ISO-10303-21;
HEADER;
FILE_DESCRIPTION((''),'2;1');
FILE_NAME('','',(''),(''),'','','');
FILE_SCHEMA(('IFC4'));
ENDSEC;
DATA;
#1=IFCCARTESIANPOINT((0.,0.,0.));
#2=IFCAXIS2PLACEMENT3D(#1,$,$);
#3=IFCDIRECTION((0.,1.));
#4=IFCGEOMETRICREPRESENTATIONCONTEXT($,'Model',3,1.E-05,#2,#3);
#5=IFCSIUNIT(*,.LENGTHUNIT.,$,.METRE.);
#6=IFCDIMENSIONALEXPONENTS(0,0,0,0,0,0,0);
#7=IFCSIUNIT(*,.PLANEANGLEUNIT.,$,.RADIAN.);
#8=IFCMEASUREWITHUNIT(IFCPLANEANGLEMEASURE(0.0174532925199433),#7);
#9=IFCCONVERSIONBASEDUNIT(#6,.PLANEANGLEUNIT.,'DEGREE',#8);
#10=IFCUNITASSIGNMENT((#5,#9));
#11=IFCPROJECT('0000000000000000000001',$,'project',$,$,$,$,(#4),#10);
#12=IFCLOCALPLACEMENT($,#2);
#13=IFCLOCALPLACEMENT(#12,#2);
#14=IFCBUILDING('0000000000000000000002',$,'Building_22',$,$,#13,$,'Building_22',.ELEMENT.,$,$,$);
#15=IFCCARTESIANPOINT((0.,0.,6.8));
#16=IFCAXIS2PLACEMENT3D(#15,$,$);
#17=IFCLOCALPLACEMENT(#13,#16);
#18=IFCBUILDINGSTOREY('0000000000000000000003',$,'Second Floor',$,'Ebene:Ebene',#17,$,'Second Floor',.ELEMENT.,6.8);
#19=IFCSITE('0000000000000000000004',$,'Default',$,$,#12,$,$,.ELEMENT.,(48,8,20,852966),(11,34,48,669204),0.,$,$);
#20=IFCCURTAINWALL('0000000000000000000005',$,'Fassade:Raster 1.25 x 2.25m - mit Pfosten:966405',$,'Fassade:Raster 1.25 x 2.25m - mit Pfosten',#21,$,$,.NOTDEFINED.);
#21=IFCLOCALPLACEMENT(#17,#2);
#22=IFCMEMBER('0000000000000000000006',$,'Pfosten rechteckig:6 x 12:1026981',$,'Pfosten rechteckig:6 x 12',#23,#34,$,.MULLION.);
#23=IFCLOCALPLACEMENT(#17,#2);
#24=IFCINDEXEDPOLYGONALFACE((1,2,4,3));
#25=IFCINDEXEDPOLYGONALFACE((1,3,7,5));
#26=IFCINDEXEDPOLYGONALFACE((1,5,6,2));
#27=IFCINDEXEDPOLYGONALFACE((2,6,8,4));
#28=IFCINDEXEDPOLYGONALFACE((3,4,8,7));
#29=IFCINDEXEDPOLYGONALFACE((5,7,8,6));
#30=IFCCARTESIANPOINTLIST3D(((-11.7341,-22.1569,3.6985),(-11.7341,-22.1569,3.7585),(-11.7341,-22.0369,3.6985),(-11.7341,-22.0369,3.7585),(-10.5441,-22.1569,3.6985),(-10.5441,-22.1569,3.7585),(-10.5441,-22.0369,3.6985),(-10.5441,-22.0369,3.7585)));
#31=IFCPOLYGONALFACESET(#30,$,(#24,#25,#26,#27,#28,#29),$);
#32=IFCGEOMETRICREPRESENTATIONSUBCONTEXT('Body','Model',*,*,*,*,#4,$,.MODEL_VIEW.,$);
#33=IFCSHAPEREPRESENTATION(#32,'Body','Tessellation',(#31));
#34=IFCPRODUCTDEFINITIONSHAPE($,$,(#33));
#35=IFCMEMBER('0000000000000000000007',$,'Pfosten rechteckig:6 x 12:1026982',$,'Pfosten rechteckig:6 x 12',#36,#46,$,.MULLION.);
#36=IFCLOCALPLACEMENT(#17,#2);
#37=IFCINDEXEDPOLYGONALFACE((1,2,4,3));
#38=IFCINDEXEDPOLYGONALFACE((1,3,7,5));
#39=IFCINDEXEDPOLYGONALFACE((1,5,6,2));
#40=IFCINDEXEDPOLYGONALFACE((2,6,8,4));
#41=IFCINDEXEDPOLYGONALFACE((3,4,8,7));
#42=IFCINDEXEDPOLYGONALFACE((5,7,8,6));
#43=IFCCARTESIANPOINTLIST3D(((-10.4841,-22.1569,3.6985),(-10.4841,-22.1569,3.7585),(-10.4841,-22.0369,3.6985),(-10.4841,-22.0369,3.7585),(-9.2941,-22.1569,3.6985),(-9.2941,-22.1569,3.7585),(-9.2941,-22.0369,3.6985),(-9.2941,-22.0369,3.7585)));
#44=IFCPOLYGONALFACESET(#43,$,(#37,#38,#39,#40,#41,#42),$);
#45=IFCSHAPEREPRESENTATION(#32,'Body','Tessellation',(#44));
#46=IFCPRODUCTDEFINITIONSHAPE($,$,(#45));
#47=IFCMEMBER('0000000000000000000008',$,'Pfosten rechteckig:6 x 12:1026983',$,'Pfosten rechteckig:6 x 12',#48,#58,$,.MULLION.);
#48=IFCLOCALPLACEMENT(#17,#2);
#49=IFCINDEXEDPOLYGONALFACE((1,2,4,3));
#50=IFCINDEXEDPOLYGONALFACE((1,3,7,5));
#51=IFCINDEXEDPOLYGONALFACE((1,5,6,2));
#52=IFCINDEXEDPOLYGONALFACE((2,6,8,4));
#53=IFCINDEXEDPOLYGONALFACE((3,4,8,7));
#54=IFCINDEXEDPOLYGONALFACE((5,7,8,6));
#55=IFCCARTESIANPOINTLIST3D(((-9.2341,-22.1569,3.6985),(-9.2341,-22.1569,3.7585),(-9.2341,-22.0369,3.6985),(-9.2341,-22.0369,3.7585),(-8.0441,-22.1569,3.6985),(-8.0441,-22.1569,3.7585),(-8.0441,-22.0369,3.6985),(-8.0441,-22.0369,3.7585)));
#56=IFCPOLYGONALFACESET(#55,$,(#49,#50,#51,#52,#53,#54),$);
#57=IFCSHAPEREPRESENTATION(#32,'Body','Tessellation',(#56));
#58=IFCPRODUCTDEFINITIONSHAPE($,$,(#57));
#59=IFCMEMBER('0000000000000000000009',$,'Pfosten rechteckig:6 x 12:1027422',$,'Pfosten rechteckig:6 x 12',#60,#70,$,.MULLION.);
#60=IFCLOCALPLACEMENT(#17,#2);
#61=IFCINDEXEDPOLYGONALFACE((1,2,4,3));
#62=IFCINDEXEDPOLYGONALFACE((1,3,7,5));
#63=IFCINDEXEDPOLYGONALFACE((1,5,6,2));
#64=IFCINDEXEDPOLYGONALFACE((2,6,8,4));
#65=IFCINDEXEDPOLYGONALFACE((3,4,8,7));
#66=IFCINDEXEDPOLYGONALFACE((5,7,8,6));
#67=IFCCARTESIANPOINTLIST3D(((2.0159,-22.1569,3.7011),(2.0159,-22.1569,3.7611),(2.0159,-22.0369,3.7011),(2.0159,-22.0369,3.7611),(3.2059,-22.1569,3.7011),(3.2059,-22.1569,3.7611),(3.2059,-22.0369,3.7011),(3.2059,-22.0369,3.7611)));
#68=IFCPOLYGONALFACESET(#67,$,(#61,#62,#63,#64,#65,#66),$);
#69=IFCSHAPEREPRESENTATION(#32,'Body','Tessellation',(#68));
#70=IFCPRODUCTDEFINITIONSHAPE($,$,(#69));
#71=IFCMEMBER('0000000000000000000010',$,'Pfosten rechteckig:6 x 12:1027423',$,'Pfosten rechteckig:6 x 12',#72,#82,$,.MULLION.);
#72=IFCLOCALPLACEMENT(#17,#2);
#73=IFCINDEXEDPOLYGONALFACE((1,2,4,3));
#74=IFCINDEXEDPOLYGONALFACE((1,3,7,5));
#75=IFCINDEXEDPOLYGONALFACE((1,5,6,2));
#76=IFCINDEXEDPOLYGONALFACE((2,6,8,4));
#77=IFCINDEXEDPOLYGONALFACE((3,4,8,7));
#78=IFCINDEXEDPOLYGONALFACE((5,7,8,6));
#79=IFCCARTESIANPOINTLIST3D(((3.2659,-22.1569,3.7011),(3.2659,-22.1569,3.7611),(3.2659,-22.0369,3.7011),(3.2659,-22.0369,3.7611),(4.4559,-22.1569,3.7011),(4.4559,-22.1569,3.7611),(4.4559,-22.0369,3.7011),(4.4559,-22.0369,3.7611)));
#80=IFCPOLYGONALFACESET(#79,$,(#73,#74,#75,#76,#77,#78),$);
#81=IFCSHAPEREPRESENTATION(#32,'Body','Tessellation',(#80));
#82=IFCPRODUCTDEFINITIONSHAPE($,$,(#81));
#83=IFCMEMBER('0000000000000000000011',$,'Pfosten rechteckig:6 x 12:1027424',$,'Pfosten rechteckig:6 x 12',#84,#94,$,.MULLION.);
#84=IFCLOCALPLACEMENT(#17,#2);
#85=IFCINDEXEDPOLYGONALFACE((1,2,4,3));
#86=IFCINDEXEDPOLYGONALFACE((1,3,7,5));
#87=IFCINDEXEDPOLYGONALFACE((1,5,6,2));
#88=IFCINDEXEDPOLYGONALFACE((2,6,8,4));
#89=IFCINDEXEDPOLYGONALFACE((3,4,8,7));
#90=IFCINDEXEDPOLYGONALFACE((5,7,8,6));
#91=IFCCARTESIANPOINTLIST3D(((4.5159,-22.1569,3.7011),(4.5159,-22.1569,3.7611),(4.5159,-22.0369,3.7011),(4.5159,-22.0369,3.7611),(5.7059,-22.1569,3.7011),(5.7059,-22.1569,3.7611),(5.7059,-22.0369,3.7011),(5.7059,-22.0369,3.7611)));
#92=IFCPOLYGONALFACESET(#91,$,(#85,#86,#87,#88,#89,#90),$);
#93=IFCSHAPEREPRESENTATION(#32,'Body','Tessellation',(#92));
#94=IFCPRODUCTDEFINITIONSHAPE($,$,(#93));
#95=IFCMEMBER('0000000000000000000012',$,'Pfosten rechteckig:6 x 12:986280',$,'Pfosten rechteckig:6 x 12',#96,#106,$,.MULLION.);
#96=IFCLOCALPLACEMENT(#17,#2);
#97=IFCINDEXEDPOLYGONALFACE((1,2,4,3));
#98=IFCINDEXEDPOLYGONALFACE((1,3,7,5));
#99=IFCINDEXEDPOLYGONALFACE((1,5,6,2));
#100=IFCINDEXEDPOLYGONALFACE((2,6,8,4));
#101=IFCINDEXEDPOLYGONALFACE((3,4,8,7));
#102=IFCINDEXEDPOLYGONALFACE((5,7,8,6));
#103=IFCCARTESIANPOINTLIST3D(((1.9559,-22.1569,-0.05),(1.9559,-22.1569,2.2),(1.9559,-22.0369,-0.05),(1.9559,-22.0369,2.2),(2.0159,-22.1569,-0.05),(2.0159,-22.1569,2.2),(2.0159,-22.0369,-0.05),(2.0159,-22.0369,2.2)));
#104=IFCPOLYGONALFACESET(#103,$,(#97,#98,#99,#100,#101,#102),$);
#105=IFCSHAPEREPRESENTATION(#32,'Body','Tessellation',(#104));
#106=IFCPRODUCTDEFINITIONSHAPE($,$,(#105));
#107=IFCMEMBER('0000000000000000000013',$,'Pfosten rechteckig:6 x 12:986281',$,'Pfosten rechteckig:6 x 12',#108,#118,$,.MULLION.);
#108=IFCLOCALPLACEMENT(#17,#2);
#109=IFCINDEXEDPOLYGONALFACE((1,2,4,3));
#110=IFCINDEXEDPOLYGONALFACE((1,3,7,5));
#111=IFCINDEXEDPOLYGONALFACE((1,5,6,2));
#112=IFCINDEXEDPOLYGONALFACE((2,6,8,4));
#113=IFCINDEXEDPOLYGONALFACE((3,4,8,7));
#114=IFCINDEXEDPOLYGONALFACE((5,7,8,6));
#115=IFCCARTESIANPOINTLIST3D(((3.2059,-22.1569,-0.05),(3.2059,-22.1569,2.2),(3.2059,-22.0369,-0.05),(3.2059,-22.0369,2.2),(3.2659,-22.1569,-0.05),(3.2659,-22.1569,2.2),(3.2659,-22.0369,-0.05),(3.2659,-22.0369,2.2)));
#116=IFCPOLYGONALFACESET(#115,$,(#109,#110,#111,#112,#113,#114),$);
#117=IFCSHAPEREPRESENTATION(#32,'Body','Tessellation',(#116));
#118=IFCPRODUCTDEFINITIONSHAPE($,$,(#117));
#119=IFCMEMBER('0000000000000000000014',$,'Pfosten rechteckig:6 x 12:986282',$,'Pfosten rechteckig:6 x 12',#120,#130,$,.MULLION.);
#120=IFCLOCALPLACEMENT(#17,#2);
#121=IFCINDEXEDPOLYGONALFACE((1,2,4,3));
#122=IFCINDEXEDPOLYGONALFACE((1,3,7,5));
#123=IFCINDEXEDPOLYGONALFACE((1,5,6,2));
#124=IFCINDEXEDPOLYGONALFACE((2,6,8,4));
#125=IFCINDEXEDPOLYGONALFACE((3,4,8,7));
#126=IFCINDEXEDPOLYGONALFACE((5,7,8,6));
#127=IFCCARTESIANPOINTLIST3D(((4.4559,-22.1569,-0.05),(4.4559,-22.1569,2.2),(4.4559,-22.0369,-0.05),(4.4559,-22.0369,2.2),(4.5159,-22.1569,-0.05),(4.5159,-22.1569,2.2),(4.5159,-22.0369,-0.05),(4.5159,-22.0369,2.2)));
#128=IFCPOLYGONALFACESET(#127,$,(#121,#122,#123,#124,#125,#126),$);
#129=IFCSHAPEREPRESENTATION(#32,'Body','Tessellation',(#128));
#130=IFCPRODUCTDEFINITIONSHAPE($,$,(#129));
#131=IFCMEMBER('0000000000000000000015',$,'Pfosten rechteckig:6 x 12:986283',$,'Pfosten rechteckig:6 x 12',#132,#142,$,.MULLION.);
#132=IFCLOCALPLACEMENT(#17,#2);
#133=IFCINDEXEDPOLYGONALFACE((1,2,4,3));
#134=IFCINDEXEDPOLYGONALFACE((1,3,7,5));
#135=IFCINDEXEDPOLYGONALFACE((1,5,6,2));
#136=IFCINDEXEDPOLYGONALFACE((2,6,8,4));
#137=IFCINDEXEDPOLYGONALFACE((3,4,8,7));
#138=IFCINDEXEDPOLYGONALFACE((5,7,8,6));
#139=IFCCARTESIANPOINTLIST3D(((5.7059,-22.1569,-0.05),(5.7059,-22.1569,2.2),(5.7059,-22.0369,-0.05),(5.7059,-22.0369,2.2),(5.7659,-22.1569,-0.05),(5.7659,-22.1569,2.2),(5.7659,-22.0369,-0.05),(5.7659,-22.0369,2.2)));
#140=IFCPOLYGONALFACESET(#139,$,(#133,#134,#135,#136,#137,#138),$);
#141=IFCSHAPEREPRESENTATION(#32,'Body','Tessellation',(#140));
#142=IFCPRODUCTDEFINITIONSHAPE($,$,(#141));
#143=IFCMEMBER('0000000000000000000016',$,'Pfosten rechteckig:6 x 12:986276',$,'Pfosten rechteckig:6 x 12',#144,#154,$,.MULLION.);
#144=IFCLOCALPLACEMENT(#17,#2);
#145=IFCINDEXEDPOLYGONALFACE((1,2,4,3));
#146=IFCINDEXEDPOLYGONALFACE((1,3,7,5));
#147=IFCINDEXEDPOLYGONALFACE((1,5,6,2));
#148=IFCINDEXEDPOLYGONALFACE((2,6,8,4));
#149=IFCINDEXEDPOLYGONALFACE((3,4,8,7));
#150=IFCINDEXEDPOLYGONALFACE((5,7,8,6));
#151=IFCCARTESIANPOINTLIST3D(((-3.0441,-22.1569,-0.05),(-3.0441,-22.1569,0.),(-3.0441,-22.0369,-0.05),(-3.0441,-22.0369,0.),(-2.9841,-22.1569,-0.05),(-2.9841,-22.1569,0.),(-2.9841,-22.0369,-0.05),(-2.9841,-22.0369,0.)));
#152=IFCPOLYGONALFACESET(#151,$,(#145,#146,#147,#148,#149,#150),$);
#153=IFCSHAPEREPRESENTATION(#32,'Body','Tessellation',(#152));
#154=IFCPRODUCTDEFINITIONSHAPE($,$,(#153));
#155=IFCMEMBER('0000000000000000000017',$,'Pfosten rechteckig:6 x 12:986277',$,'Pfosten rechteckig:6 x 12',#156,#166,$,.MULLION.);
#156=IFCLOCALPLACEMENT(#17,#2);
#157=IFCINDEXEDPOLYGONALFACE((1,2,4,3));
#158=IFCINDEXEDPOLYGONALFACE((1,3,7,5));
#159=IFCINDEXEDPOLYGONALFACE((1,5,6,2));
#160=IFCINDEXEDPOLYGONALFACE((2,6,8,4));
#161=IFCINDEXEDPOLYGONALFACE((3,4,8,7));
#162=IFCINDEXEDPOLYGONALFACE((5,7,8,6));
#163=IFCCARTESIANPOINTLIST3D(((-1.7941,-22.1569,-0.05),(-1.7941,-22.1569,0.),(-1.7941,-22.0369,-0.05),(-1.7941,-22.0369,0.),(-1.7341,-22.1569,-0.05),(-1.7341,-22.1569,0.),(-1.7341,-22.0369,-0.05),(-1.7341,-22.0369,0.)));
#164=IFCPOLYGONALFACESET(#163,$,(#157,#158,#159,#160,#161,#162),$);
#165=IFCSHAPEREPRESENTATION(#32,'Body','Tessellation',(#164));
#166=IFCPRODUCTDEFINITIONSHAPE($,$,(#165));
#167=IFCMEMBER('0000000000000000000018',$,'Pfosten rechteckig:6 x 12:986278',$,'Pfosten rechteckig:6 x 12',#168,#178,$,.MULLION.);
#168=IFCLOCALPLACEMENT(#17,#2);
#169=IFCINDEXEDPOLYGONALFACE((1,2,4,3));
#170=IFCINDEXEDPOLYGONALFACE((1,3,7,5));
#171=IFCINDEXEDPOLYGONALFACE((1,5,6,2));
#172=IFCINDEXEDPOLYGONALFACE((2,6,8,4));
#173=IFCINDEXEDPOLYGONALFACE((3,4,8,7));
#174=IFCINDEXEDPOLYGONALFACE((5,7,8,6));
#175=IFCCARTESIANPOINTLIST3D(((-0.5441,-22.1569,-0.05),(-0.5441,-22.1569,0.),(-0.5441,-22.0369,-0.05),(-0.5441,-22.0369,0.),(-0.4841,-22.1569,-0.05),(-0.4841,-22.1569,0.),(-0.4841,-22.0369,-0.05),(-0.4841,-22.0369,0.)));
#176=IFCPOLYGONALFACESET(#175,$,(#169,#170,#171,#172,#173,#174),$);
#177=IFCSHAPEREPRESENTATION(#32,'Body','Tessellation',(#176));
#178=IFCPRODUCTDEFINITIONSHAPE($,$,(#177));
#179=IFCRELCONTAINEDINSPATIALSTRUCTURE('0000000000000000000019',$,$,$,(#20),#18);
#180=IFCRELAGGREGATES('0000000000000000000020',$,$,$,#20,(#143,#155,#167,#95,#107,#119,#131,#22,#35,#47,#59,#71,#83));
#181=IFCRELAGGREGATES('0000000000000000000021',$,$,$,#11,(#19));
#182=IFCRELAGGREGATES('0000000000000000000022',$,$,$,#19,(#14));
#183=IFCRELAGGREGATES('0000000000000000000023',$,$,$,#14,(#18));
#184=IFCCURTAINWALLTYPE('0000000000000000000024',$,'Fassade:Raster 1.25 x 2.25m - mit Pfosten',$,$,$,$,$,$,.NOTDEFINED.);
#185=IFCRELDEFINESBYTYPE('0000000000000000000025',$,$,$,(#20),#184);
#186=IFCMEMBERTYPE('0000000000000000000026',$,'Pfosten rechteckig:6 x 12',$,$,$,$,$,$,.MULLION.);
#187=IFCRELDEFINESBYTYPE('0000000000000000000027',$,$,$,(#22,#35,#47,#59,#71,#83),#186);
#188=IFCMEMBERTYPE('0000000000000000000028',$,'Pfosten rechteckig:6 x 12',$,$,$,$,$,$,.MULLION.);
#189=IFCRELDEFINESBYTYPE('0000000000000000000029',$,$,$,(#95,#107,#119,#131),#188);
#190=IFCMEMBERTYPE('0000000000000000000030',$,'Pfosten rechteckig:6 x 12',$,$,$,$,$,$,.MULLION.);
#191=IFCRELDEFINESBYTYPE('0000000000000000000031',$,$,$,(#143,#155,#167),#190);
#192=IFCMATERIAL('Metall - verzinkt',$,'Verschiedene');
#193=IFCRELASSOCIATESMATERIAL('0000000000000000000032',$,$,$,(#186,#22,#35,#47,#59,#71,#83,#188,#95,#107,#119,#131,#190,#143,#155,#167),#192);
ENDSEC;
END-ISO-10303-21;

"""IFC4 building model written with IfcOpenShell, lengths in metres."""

from ifc_helpers import new_model, entity, si_unit, converted_unit, direction, frame, origin, place, context, subcontext, project, spatial, indexed_curve, outline, extrude, source, transform, mapped, material, type_object, type_shapes, element, aggregate, save


model = new_model("IFC4")

# Units and contexts
model_context = context("Model", 3, precision=1e-05, world=origin(), true_north=direction((0.0, 1.0)))
body_context = subcontext(model_context, "Body", "Model", "MODEL_VIEW")
ifc_project = project(units=[si_unit("LENGTHUNIT", "METRE"), converted_unit("PLANEANGLEUNIT", "DEGREE", entity("IfcPlaneAngleMeasure", 0.0174532925199433), si_unit("PLANEANGLEUNIT", "RADIAN"), dimensions=[0, 0, 0, 0, 0, 0, 0])], contexts=[model_context])

# Site, building, storey
site_placement = place(None, origin())
site = spatial("IfcSite", under=ifc_project, at=site_placement, Name="Default", CompositionType="ELEMENT", RefLatitude=(48, 8, 20, 852966), RefLongitude=(11, 34, 48, 669204), RefElevation=0.0)
building_placement = place(site_placement, origin())
building = spatial("IfcBuilding", under=site, at=building_placement, Name="Building_22", LongName="Building_22", CompositionType="ELEMENT")
storey_placement = place(building_placement, frame((0.0, 0.0, 6.8)))
storey = spatial("IfcBuildingStorey", under=building, at=storey_placement, Name="Second Floor", ObjectType="Ebene:Ebene", LongName="Second Floor", CompositionType="ELEMENT", Elevation=6.8)

# Curtain wall, members
curtain_wall_type = type_object("IfcCurtainWallType", Name="Fassade:Raster 1.25 x 2.25m - mit Pfosten", PredefinedType="NOTDEFINED")
curtain_wall_placement = place(storey_placement, frame((0.0, 0.0, -6.8)))
curtain_wall = element("IfcCurtainWall", 1, at=curtain_wall_placement, inside=storey, type_object=curtain_wall_type, Name="Fassade:Raster 1.25 x 2.25m - mit Pfosten:966405", ObjectType="Fassade:Raster 1.25 x 2.25m - mit Pfosten", PredefinedType="NOTDEFINED")
ifc_material = material(Name="Metall - verzinkt", Category="Verschiedene")
member_type_1 = type_object("IfcMemberType", Name="Pfosten rechteckig:6 x 12", PredefinedType="MULLION", material=ifc_material)
shared_shape_1 = source(origin(), body_context, "Body", "SweptSolid", [
    extrude(outline(indexed_curve([(-0.03, -0.06), (0.03, -0.06), (0.03, 0.06), (-0.03, 0.06), (-0.03, -0.06)], self_intersect=False)), frame((-0.03, 0.0, -1.19), z_axis=(0.0, 0.0, 1.0), x_axis=(-1.0, 0.0, 0.0)), (0.0, 0.0, 1.0), 1.19),
])
type_shapes(member_type_1, [shared_shape_1])
member_1_placement = place(curtain_wall_placement, frame((-10.5441, -22.0969, 10.5585), z_axis=(1.0, 0.0, 0.0), x_axis=(0.0, 0.0, 1.0)))
member_1 = element("IfcMember", 2, at=member_1_placement, type_object=member_type_1, material=ifc_material, Name="Pfosten rechteckig:6 x 12:1026981", ObjectType="Pfosten rechteckig:6 x 12", PredefinedType="MULLION", context=body_context, shape_type="MappedRepresentation", body=[
    mapped(shared_shape_1, transform((0.0, 0.0, 0.0), scale=1.0)),
])
member_2_placement = place(curtain_wall_placement, frame((-9.2941, -22.0969, 10.5585), z_axis=(1.0, 0.0, 0.0), x_axis=(0.0, 0.0, 1.0)))
member_2 = element("IfcMember", 3, at=member_2_placement, type_object=member_type_1, material=ifc_material, Name="Pfosten rechteckig:6 x 12:1026982", ObjectType="Pfosten rechteckig:6 x 12", PredefinedType="MULLION", context=body_context, shape_type="MappedRepresentation", body=[
    mapped(shared_shape_1, transform((0.0, 0.0, 0.0), scale=1.0)),
])
member_3_placement = place(curtain_wall_placement, frame((-8.0441, -22.0969, 10.5585), z_axis=(1.0, 0.0, 0.0), x_axis=(0.0, 0.0, 1.0)))
member_3 = element("IfcMember", 4, at=member_3_placement, type_object=member_type_1, material=ifc_material, Name="Pfosten rechteckig:6 x 12:1026983", ObjectType="Pfosten rechteckig:6 x 12", PredefinedType="MULLION", context=body_context, shape_type="MappedRepresentation", body=[
    mapped(shared_shape_1, transform((0.0, 0.0, 0.0), scale=1.0)),
])
member_4_placement = place(curtain_wall_placement, frame((3.2059, -22.0969, 10.5611), z_axis=(1.0, 0.0, 0.0), x_axis=(0.0, 0.0, 1.0)))
member_4 = element("IfcMember", 5, at=member_4_placement, type_object=member_type_1, material=ifc_material, Name="Pfosten rechteckig:6 x 12:1027422", ObjectType="Pfosten rechteckig:6 x 12", PredefinedType="MULLION", context=body_context, shape_type="MappedRepresentation", body=[
    mapped(shared_shape_1, transform((0.0, 0.0, 0.0), scale=1.0)),
])
member_5_placement = place(curtain_wall_placement, frame((4.4559, -22.0969, 10.5611), z_axis=(1.0, 0.0, 0.0), x_axis=(0.0, 0.0, 1.0)))
member_5 = element("IfcMember", 6, at=member_5_placement, type_object=member_type_1, material=ifc_material, Name="Pfosten rechteckig:6 x 12:1027423", ObjectType="Pfosten rechteckig:6 x 12", PredefinedType="MULLION", context=body_context, shape_type="MappedRepresentation", body=[
    mapped(shared_shape_1, transform((0.0, 0.0, 0.0), scale=1.0)),
])
member_6_placement = place(curtain_wall_placement, frame((5.7059, -22.0969, 10.5611), z_axis=(1.0, 0.0, 0.0), x_axis=(0.0, 0.0, 1.0)))
member_6 = element("IfcMember", 7, at=member_6_placement, type_object=member_type_1, material=ifc_material, Name="Pfosten rechteckig:6 x 12:1027424", ObjectType="Pfosten rechteckig:6 x 12", PredefinedType="MULLION", context=body_context, shape_type="MappedRepresentation", body=[
    mapped(shared_shape_1, transform((0.0, 0.0, 0.0), scale=1.0)),
])
member_type_2 = type_object("IfcMemberType", Name="Pfosten rechteckig:6 x 12", PredefinedType="MULLION", material=ifc_material)
shared_shape_2 = source(origin(), body_context, "Body", "SweptSolid", [
    extrude(outline(indexed_curve([(-0.03, -0.06), (0.03, -0.06), (0.03, 0.06), (-0.03, 0.06), (-0.03, -0.06)], self_intersect=False)), frame((0.0, 0.0, -2.25), z_axis=(0.0, 0.0, 1.0), x_axis=(-1.0, 0.0, 0.0)), (0.0, 0.0, 1.0), 2.25),
])
type_shapes(member_type_2, [shared_shape_2])
member_7_placement = place(curtain_wall_placement, frame((1.9859, -22.0969, 6.75), z_axis=(0.0, 0.0, -1.0), x_axis=(1.0, 0.0, 0.0)))
member_7 = element("IfcMember", 8, at=member_7_placement, type_object=member_type_2, material=ifc_material, Name="Pfosten rechteckig:6 x 12:986280", ObjectType="Pfosten rechteckig:6 x 12", PredefinedType="MULLION", context=body_context, shape_type="MappedRepresentation", body=[
    mapped(shared_shape_2, transform((0.0, 0.0, 0.0), scale=1.0)),
])
member_8_placement = place(curtain_wall_placement, frame((3.2359, -22.0969, 6.75), z_axis=(0.0, 0.0, -1.0), x_axis=(1.0, 0.0, 0.0)))
member_8 = element("IfcMember", 9, at=member_8_placement, type_object=member_type_2, material=ifc_material, Name="Pfosten rechteckig:6 x 12:986281", ObjectType="Pfosten rechteckig:6 x 12", PredefinedType="MULLION", context=body_context, shape_type="MappedRepresentation", body=[
    mapped(shared_shape_2, transform((0.0, 0.0, 0.0), scale=1.0)),
])
member_9_placement = place(curtain_wall_placement, frame((4.4859, -22.0969, 6.75), z_axis=(0.0, 0.0, -1.0), x_axis=(1.0, 0.0, 0.0)))
member_9 = element("IfcMember", 10, at=member_9_placement, type_object=member_type_2, material=ifc_material, Name="Pfosten rechteckig:6 x 12:986282", ObjectType="Pfosten rechteckig:6 x 12", PredefinedType="MULLION", context=body_context, shape_type="MappedRepresentation", body=[
    mapped(shared_shape_2, transform((0.0, 0.0, 0.0), scale=1.0)),
])
member_10_placement = place(curtain_wall_placement, frame((5.7359, -22.0969, 6.75), z_axis=(0.0, 0.0, -1.0), x_axis=(1.0, 0.0, 0.0)))
member_10 = element("IfcMember", 11, at=member_10_placement, type_object=member_type_2, material=ifc_material, Name="Pfosten rechteckig:6 x 12:986283", ObjectType="Pfosten rechteckig:6 x 12", PredefinedType="MULLION", context=body_context, shape_type="MappedRepresentation", body=[
    mapped(shared_shape_2, transform((0.0, 0.0, 0.0), scale=1.0)),
])
member_type_3 = type_object("IfcMemberType", Name="Pfosten rechteckig:6 x 12", PredefinedType="MULLION", material=ifc_material)
shared_shape_3 = source(origin(), body_context, "Body", "SweptSolid", [
    extrude(outline(indexed_curve([(-0.03, -0.06), (0.03, -0.06), (0.03, 0.06), (-0.03, 0.06), (-0.03, -0.06)], self_intersect=False)), frame((0.0, 0.0, -0.05), z_axis=(0.0, 0.0, 1.0), x_axis=(-1.0, 0.0, 0.0)), (0.0, 0.0, 1.0), 0.05),
])
type_shapes(member_type_3, [shared_shape_3])
member_11_placement = place(curtain_wall_placement, frame((-3.0141, -22.0969, 6.75), z_axis=(0.0, 0.0, -1.0), x_axis=(1.0, 0.0, 0.0)))
member_11 = element("IfcMember", 12, at=member_11_placement, type_object=member_type_3, material=ifc_material, Name="Pfosten rechteckig:6 x 12:986276", ObjectType="Pfosten rechteckig:6 x 12", PredefinedType="MULLION", context=body_context, shape_type="MappedRepresentation", body=[
    mapped(shared_shape_3, transform((0.0, 0.0, 0.0), scale=1.0)),
])
member_12_placement = place(curtain_wall_placement, frame((-1.7641, -22.0969, 6.75), z_axis=(0.0, 0.0, -1.0), x_axis=(1.0, 0.0, 0.0)))
member_12 = element("IfcMember", 13, at=member_12_placement, type_object=member_type_3, material=ifc_material, Name="Pfosten rechteckig:6 x 12:986277", ObjectType="Pfosten rechteckig:6 x 12", PredefinedType="MULLION", context=body_context, shape_type="MappedRepresentation", body=[
    mapped(shared_shape_3, transform((0.0, 0.0, 0.0), scale=1.0)),
])
member_13_placement = place(curtain_wall_placement, frame((-0.5141, -22.0969, 6.75), z_axis=(0.0, 0.0, -1.0), x_axis=(1.0, 0.0, 0.0)))
member_13 = element("IfcMember", 14, at=member_13_placement, type_object=member_type_3, material=ifc_material, Name="Pfosten rechteckig:6 x 12:986278", ObjectType="Pfosten rechteckig:6 x 12", PredefinedType="MULLION", context=body_context, shape_type="MappedRepresentation", body=[
    mapped(shared_shape_3, transform((0.0, 0.0, 0.0), scale=1.0)),
])
aggregate(curtain_wall, [member_11, member_12, member_13, member_7, member_8, member_9, member_10, member_1, member_2, member_3, member_4, member_5, member_6])

save(model, "model.ifc")
